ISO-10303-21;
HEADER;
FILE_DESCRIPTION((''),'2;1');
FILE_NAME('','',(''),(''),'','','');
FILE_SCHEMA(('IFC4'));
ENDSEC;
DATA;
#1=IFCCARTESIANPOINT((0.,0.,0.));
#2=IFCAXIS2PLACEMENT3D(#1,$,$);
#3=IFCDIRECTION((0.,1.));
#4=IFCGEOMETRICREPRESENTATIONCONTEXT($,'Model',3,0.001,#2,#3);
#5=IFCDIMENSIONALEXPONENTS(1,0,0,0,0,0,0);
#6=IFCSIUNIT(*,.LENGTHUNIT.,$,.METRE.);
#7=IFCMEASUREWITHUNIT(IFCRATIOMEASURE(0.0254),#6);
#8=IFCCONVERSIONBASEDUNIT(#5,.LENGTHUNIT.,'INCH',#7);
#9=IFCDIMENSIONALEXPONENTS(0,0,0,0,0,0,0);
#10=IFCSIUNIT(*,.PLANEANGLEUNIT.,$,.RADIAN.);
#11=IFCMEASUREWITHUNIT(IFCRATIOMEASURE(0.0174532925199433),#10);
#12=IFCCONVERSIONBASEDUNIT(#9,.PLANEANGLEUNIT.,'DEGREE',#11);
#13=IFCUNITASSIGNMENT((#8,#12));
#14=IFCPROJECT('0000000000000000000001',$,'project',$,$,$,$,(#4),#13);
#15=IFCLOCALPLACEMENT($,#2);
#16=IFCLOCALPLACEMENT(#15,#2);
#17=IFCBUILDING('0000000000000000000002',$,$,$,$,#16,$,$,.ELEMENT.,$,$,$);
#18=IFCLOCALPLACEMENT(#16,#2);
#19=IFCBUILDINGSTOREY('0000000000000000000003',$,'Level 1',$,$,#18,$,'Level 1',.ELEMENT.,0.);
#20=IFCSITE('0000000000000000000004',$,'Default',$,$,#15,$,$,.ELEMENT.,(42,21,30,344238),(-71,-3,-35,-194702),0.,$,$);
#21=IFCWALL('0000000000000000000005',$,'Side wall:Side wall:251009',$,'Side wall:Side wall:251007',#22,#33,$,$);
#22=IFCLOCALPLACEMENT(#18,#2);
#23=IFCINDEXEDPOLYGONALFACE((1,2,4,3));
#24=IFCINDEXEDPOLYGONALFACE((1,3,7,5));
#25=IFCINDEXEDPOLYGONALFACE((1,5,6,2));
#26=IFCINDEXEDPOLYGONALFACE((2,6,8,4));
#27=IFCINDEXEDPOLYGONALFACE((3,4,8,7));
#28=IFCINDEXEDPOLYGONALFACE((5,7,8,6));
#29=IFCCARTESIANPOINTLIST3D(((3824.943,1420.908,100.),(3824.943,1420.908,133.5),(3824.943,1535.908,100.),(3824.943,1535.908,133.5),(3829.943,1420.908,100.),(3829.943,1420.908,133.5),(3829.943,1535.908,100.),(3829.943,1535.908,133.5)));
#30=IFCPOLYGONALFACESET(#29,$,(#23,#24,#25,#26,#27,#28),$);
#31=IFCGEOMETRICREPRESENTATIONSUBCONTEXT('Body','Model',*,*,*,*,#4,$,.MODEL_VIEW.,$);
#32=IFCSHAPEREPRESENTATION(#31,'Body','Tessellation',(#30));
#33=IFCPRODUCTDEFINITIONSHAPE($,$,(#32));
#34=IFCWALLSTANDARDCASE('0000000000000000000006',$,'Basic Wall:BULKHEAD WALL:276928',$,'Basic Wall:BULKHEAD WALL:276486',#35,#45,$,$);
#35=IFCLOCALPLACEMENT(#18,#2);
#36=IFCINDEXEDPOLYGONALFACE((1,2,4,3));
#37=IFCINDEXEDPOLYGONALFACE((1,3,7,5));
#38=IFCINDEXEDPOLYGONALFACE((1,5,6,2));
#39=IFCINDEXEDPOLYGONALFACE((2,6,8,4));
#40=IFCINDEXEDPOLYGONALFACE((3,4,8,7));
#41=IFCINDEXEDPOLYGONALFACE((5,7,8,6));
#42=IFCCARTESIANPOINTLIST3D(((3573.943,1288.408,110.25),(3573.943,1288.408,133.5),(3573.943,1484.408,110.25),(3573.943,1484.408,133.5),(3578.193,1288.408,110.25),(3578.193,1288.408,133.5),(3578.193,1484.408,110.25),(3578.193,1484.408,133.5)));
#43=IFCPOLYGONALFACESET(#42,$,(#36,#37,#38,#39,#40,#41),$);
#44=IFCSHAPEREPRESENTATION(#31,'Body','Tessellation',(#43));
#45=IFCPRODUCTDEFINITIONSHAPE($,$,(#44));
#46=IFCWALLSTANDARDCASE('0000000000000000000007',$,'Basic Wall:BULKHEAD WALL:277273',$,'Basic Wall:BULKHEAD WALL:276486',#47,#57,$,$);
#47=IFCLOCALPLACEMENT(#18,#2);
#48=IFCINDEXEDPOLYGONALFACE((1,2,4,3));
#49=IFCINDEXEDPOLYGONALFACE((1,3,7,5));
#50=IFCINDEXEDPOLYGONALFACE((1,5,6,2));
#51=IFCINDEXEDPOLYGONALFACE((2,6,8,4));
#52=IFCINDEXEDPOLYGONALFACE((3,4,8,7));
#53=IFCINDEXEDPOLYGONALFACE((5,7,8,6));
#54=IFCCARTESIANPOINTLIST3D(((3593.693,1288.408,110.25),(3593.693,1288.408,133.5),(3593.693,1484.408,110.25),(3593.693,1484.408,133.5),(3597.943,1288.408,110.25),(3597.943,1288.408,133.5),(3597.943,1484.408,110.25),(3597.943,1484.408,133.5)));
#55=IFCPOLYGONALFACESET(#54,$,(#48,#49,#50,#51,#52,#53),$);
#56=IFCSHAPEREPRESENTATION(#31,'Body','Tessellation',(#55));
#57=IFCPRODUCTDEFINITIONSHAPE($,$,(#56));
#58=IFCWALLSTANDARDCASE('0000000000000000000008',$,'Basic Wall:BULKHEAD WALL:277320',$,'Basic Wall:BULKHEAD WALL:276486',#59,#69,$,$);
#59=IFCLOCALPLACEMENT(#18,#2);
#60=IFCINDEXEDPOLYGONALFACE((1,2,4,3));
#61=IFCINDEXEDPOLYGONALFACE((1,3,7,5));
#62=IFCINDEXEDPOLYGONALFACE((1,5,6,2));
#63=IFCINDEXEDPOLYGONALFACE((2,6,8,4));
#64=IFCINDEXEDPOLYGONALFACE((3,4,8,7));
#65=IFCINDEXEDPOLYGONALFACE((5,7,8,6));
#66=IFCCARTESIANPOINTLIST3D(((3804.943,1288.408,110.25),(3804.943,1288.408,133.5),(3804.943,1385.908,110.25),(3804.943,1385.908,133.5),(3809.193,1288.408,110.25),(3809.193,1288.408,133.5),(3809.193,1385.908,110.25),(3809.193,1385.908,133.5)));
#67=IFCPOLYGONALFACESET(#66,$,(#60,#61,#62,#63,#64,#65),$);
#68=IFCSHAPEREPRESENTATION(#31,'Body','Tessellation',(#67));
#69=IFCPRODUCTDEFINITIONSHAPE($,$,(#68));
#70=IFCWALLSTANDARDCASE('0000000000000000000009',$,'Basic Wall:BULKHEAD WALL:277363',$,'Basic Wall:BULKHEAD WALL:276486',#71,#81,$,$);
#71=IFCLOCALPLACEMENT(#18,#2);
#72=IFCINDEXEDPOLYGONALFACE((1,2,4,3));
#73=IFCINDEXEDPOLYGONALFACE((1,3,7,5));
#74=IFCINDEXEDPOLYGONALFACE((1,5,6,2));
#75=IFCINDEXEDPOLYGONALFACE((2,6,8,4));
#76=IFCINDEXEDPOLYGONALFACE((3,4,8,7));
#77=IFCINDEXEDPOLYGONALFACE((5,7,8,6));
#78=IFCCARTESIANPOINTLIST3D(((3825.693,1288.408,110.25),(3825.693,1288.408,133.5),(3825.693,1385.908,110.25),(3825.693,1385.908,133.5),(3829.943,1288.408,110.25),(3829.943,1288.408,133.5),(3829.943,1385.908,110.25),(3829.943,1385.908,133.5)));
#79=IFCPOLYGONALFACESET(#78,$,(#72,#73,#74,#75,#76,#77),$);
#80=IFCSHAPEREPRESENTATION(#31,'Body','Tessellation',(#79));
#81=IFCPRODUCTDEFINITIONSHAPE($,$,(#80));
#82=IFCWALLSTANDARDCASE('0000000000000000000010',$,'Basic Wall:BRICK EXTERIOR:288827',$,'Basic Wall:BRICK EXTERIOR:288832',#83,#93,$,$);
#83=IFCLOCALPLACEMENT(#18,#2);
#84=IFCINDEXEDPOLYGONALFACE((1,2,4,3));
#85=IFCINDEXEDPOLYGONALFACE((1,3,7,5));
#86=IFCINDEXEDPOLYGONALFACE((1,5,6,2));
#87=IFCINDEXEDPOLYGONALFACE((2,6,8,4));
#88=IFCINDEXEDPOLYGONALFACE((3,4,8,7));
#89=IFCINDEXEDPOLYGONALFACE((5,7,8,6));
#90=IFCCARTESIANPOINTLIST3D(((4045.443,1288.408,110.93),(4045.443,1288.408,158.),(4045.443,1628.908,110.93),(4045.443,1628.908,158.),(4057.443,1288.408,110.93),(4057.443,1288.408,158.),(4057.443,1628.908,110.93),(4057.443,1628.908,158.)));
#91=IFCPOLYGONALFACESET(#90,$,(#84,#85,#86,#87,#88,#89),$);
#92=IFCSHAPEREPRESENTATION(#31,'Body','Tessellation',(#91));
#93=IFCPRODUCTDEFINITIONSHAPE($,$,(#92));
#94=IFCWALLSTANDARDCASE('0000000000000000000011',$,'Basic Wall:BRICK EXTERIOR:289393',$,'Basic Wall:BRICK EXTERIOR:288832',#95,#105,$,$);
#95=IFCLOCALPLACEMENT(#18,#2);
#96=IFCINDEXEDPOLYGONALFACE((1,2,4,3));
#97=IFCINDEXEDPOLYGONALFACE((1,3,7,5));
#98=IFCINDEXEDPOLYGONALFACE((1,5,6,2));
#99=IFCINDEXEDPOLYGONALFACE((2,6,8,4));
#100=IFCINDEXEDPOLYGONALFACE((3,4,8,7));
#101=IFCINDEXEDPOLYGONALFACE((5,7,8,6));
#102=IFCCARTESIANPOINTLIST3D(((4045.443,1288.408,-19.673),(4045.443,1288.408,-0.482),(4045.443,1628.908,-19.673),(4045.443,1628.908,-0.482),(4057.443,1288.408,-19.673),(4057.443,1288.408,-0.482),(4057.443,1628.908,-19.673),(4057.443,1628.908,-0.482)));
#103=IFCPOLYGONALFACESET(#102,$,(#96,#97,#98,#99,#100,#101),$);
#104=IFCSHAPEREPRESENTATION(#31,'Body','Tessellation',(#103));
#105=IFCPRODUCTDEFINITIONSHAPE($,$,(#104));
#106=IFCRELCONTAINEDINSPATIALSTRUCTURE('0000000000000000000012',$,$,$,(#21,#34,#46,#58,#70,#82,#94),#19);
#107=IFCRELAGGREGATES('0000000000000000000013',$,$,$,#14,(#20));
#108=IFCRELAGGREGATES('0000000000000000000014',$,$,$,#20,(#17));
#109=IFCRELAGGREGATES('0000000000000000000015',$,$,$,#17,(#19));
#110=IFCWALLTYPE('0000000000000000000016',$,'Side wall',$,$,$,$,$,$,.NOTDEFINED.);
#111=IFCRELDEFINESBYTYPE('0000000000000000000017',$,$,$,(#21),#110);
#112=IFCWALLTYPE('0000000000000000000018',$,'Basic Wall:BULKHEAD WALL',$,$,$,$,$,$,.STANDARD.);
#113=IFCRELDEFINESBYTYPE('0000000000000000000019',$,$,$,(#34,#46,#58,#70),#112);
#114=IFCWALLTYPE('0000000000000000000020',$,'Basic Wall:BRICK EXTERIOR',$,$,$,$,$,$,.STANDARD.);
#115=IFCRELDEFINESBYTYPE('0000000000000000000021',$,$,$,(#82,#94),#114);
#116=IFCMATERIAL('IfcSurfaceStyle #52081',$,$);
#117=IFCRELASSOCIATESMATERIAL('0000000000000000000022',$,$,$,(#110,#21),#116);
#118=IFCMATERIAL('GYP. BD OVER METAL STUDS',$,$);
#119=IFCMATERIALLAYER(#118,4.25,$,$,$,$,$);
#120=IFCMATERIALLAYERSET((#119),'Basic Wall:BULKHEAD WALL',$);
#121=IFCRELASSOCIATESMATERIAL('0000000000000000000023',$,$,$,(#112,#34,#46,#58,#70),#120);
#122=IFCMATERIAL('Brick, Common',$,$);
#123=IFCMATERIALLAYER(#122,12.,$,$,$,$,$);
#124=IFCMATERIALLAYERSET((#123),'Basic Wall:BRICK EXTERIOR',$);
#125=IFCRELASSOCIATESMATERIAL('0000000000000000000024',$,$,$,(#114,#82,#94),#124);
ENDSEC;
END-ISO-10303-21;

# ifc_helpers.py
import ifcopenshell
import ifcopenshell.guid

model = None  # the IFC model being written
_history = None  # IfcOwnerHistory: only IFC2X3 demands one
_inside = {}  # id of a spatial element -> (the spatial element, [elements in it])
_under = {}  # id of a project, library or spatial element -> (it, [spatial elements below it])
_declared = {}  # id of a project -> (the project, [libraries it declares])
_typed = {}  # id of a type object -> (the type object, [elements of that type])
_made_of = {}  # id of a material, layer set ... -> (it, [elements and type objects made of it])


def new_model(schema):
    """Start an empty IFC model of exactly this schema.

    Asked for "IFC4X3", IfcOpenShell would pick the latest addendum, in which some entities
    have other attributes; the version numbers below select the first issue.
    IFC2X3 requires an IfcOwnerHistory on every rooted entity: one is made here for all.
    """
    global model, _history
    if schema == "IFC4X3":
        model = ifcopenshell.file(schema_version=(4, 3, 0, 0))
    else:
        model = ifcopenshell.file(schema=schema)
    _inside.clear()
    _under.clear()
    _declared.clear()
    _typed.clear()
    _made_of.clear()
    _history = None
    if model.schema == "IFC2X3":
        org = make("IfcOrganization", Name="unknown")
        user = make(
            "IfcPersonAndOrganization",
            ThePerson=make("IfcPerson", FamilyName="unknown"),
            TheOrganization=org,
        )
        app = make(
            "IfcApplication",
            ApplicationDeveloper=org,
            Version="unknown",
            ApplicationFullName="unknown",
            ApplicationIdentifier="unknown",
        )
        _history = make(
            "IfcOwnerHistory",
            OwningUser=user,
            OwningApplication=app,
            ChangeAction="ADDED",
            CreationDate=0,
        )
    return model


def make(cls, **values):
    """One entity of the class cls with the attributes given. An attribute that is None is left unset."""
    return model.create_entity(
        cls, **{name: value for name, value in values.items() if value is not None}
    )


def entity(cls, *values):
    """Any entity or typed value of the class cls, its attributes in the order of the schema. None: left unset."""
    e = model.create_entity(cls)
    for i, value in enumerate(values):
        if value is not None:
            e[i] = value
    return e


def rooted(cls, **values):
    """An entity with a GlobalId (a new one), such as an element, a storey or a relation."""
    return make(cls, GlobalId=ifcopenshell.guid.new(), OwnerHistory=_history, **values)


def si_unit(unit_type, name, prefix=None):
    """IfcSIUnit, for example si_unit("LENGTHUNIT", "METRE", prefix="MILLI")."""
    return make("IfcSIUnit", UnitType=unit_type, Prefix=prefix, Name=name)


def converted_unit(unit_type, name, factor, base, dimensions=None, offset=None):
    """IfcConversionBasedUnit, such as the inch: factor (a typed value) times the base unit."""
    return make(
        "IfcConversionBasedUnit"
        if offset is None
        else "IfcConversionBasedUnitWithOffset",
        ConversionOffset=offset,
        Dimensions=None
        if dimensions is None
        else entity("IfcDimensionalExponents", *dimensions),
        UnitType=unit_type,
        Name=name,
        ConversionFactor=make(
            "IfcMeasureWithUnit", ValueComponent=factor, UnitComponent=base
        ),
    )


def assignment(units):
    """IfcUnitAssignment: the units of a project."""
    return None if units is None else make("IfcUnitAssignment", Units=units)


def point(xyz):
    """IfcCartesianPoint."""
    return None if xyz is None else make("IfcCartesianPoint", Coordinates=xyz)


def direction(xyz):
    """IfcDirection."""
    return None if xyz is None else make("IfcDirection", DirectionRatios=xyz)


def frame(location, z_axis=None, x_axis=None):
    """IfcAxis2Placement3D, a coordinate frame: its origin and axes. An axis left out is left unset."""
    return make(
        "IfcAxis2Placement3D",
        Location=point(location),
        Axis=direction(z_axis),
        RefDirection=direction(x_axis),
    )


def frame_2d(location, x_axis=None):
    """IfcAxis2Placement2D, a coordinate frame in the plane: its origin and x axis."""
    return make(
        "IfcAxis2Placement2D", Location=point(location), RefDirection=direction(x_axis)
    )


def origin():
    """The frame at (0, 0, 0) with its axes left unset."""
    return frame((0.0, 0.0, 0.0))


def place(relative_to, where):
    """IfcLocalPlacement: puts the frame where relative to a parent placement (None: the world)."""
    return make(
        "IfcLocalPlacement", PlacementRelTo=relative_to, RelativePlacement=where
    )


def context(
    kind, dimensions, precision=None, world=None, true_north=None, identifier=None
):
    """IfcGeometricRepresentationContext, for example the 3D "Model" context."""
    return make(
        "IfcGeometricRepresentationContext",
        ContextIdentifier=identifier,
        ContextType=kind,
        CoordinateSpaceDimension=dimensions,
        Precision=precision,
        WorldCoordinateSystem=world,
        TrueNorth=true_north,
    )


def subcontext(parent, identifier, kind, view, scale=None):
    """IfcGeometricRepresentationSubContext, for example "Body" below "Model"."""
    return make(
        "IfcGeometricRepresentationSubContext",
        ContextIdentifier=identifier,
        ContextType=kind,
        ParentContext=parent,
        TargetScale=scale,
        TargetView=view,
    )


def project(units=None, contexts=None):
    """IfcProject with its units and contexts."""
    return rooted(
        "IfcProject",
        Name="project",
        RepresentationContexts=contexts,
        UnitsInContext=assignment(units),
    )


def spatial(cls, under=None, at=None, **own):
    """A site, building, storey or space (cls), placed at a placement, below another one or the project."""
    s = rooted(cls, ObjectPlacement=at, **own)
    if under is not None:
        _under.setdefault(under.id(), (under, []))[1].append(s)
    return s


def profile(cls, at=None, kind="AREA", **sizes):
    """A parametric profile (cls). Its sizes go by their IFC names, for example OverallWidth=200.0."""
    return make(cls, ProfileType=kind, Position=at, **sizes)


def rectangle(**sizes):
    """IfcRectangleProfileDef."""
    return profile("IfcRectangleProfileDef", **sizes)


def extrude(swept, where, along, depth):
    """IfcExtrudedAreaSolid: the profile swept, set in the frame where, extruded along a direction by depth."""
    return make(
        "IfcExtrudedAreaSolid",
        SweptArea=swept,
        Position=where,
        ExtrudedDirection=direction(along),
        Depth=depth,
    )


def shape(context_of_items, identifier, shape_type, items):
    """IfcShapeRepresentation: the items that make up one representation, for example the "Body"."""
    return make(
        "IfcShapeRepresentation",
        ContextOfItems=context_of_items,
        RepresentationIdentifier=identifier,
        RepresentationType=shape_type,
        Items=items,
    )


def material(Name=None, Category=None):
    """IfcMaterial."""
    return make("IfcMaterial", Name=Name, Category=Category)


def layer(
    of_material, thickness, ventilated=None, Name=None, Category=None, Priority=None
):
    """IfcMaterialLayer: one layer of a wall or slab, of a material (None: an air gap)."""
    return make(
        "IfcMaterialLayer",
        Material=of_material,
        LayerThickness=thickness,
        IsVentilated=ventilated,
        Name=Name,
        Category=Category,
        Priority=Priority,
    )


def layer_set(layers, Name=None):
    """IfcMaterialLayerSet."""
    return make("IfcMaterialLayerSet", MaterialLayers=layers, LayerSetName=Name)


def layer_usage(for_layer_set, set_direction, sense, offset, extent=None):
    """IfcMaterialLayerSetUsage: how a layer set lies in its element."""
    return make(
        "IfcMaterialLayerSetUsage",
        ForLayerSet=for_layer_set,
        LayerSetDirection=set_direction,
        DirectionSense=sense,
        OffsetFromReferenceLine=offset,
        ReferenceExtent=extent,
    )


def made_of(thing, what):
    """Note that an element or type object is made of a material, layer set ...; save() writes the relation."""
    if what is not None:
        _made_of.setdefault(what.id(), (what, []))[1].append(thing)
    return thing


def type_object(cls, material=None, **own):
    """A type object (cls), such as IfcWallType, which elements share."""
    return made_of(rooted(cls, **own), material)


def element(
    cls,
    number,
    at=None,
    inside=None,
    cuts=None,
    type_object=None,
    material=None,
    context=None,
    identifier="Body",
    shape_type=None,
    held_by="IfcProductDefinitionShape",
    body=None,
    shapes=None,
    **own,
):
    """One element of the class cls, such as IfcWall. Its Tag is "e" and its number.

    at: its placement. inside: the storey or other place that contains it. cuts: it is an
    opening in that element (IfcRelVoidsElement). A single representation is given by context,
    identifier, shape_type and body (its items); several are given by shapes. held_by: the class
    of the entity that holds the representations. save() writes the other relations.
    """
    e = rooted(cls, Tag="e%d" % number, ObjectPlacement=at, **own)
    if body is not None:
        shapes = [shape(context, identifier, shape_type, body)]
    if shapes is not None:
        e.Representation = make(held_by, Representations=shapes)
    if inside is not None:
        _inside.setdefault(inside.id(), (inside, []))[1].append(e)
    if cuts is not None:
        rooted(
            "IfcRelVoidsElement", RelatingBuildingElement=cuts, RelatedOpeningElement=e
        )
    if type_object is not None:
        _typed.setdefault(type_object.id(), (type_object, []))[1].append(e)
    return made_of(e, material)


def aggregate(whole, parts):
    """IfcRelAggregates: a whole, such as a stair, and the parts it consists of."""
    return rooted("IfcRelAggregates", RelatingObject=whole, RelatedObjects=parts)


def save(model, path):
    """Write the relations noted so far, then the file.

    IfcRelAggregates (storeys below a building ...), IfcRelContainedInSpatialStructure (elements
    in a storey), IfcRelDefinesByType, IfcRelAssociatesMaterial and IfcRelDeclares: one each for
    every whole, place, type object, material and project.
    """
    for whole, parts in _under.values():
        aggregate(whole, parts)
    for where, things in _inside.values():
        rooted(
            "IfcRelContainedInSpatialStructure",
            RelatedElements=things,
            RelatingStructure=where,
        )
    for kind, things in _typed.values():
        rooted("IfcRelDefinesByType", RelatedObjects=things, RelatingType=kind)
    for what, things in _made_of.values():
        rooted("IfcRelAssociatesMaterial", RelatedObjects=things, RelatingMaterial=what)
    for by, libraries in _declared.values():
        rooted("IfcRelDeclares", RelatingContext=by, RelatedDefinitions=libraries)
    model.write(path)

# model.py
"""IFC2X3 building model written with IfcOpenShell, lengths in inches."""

from ifc_helpers import new_model, entity, si_unit, converted_unit, direction, frame, frame_2d, origin, place, context, subcontext, project, spatial, rectangle, extrude, material, layer, layer_set, layer_usage, type_object, element, save


model = new_model("IFC2X3")

# Units and contexts
model_context = context("Model", 3, precision=0.001, world=origin(), true_north=direction((0.0, 1.0)))
body_context = subcontext(model_context, "Body", "Model", "MODEL_VIEW")
ifc_project = project(units=[converted_unit("LENGTHUNIT", "INCH", entity("IfcRatioMeasure", 0.0254), si_unit("LENGTHUNIT", "METRE"), dimensions=[1, 0, 0, 0, 0, 0, 0]), converted_unit("PLANEANGLEUNIT", "DEGREE", entity("IfcRatioMeasure", 0.0174532925199433), si_unit("PLANEANGLEUNIT", "RADIAN"), dimensions=[0, 0, 0, 0, 0, 0, 0])], contexts=[model_context])

# Site, building, storey
site_placement = place(None, origin())
site = spatial("IfcSite", under=ifc_project, at=site_placement, Name="Default", CompositionType="ELEMENT", RefLatitude=(42, 21, 30, 344238), RefLongitude=(-71, -3, -35, -194702), RefElevation=0.0)
building_placement = place(site_placement, origin())
building = spatial("IfcBuilding", under=site, at=building_placement, CompositionType="ELEMENT")
storey_placement = place(building_placement, origin())
storey = spatial("IfcBuildingStorey", under=building, at=storey_placement, Name="Level 1", LongName="Level 1", CompositionType="ELEMENT", Elevation=0.0)

# Walls
ifc_material_1 = material(Name="IfcSurfaceStyle #52081")
wall_type_1 = type_object("IfcWallType", Name="Side wall", PredefinedType="NOTDEFINED", material=ifc_material_1)
wall_1_placement = place(building_placement, frame((3824.943, 1420.908, 100.0), z_axis=(0.0, 0.0, 1.0), x_axis=(0.0, 1.0, 0.0)))
element("IfcWall", 1, at=wall_1_placement, inside=storey, type_object=wall_type_1, material=ifc_material_1, Name="Side wall:Side wall:251009", ObjectType="Side wall:Side wall:251007", context=body_context, shape_type="SweptSolid", body=[
    extrude(rectangle(XDim=115.0, YDim=5.0, at=frame_2d((0.0, 0.0), x_axis=(1.0, 0.0))), frame((57.5, -2.5, 0.0)), (0.0, 0.0, 1.0), 33.5),
])
ifc_material_2 = material(Name="GYP. BD OVER METAL STUDS")
ifc_layer_1 = layer(ifc_material_2, 4.25)
ifc_layer_set_1 = layer_set([ifc_layer_1], Name="Basic Wall:BULKHEAD WALL")
ifc_layer_usage_1 = layer_usage(ifc_layer_set_1, "AXIS2", "NEGATIVE", 2.125)
wall_type_2 = type_object("IfcWallType", Name="Basic Wall:BULKHEAD WALL", PredefinedType="STANDARD", material=ifc_layer_set_1)
wall_2_placement = place(building_placement, frame((3576.068, 1288.408, 110.25), z_axis=(0.0, 0.0, 1.0), x_axis=(0.0, 1.0, 0.0)))
element("IfcWallStandardCase", 2, at=wall_2_placement, inside=storey, type_object=wall_type_2, material=ifc_layer_usage_1, Name="Basic Wall:BULKHEAD WALL:276928", ObjectType="Basic Wall:BULKHEAD WALL:276486", context=body_context, shape_type="SweptSolid", body=[
    extrude(rectangle(XDim=196.0, YDim=4.25, at=frame_2d((98.0, 0.0), x_axis=(-1.0, 0.0))), origin(), (0.0, 0.0, 1.0), 23.25),
])
ifc_layer_usage_2 = layer_usage(ifc_layer_set_1, "AXIS2", "POSITIVE", -2.125)
wall_3_placement = place(storey_placement, frame((3595.818, 1288.408, 110.25), z_axis=(0.0, 0.0, 1.0), x_axis=(0.0, 1.0, 0.0)))
element("IfcWallStandardCase", 3, at=wall_3_placement, inside=storey, type_object=wall_type_2, material=ifc_layer_usage_2, Name="Basic Wall:BULKHEAD WALL:277273", ObjectType="Basic Wall:BULKHEAD WALL:276486", context=body_context, shape_type="SweptSolid", body=[
    extrude(rectangle(XDim=196.0, YDim=4.25, at=frame_2d((98.0, 0.0), x_axis=(-1.0, 0.0))), origin(), (0.0, 0.0, 1.0), 23.25),
])
ifc_layer_usage_3 = layer_usage(ifc_layer_set_1, "AXIS2", "NEGATIVE", 2.125)
wall_4_placement = place(storey_placement, frame((3807.068, 1288.408, 110.25), z_axis=(0.0, 0.0, 1.0), x_axis=(0.0, 1.0, 0.0)))
element("IfcWallStandardCase", 4, at=wall_4_placement, inside=storey, type_object=wall_type_2, material=ifc_layer_usage_3, Name="Basic Wall:BULKHEAD WALL:277320", ObjectType="Basic Wall:BULKHEAD WALL:276486", context=body_context, shape_type="SweptSolid", body=[
    extrude(rectangle(XDim=97.5, YDim=4.25, at=frame_2d((48.75, 0.0), x_axis=(-1.0, 0.0))), origin(), (0.0, 0.0, 1.0), 23.25),
])
ifc_layer_usage_4 = layer_usage(ifc_layer_set_1, "AXIS2", "POSITIVE", -2.125)
wall_5_placement = place(storey_placement, frame((3827.818, 1288.408, 110.25), z_axis=(0.0, 0.0, 1.0), x_axis=(0.0, 1.0, 0.0)))
element("IfcWallStandardCase", 5, at=wall_5_placement, inside=storey, type_object=wall_type_2, material=ifc_layer_usage_4, Name="Basic Wall:BULKHEAD WALL:277363", ObjectType="Basic Wall:BULKHEAD WALL:276486", context=body_context, shape_type="SweptSolid", body=[
    extrude(rectangle(XDim=97.5, YDim=4.25, at=frame_2d((48.75, 0.0), x_axis=(-1.0, 0.0))), origin(), (0.0, 0.0, 1.0), 23.25),
])
ifc_material_3 = material(Name="Brick, Common")
ifc_layer_2 = layer(ifc_material_3, 12.0)
ifc_layer_set_2 = layer_set([ifc_layer_2], Name="Basic Wall:BRICK EXTERIOR")
ifc_layer_usage_5 = layer_usage(ifc_layer_set_2, "AXIS2", "POSITIVE", -6.0)
wall_type_3 = type_object("IfcWallType", Name="Basic Wall:BRICK EXTERIOR", PredefinedType="STANDARD", material=ifc_layer_set_2)
wall_6_placement = place(storey_placement, frame((4051.443, 1288.408, 110.93), z_axis=(0.0, 0.0, 1.0), x_axis=(0.0, 1.0, 0.0)))
element("IfcWallStandardCase", 6, at=wall_6_placement, inside=storey, type_object=wall_type_3, material=ifc_layer_usage_5, Name="Basic Wall:BRICK EXTERIOR:288827", ObjectType="Basic Wall:BRICK EXTERIOR:288832", context=body_context, shape_type="SweptSolid", body=[
    extrude(rectangle(XDim=340.5, YDim=12.0, at=frame_2d((170.25, 0.0), x_axis=(-1.0, 0.0))), origin(), (0.0, 0.0, 1.0), 47.07),
])
ifc_layer_usage_6 = layer_usage(ifc_layer_set_2, "AXIS2", "POSITIVE", -6.0)
wall_7_placement = place(storey_placement, frame((4051.443, 1288.408, -19.673), z_axis=(0.0, 0.0, 1.0), x_axis=(0.0, 1.0, 0.0)))
element("IfcWallStandardCase", 7, at=wall_7_placement, inside=storey, type_object=wall_type_3, material=ifc_layer_usage_6, Name="Basic Wall:BRICK EXTERIOR:289393", ObjectType="Basic Wall:BRICK EXTERIOR:288832", context=body_context, shape_type="SweptSolid", body=[
    extrude(rectangle(XDim=340.5, YDim=12.0, at=frame_2d((170.25, 0.0), x_axis=(-1.0, 0.0))), origin(), (0.0, 0.0, 1.0), 19.192),
])

save(model, "model.ifc")
